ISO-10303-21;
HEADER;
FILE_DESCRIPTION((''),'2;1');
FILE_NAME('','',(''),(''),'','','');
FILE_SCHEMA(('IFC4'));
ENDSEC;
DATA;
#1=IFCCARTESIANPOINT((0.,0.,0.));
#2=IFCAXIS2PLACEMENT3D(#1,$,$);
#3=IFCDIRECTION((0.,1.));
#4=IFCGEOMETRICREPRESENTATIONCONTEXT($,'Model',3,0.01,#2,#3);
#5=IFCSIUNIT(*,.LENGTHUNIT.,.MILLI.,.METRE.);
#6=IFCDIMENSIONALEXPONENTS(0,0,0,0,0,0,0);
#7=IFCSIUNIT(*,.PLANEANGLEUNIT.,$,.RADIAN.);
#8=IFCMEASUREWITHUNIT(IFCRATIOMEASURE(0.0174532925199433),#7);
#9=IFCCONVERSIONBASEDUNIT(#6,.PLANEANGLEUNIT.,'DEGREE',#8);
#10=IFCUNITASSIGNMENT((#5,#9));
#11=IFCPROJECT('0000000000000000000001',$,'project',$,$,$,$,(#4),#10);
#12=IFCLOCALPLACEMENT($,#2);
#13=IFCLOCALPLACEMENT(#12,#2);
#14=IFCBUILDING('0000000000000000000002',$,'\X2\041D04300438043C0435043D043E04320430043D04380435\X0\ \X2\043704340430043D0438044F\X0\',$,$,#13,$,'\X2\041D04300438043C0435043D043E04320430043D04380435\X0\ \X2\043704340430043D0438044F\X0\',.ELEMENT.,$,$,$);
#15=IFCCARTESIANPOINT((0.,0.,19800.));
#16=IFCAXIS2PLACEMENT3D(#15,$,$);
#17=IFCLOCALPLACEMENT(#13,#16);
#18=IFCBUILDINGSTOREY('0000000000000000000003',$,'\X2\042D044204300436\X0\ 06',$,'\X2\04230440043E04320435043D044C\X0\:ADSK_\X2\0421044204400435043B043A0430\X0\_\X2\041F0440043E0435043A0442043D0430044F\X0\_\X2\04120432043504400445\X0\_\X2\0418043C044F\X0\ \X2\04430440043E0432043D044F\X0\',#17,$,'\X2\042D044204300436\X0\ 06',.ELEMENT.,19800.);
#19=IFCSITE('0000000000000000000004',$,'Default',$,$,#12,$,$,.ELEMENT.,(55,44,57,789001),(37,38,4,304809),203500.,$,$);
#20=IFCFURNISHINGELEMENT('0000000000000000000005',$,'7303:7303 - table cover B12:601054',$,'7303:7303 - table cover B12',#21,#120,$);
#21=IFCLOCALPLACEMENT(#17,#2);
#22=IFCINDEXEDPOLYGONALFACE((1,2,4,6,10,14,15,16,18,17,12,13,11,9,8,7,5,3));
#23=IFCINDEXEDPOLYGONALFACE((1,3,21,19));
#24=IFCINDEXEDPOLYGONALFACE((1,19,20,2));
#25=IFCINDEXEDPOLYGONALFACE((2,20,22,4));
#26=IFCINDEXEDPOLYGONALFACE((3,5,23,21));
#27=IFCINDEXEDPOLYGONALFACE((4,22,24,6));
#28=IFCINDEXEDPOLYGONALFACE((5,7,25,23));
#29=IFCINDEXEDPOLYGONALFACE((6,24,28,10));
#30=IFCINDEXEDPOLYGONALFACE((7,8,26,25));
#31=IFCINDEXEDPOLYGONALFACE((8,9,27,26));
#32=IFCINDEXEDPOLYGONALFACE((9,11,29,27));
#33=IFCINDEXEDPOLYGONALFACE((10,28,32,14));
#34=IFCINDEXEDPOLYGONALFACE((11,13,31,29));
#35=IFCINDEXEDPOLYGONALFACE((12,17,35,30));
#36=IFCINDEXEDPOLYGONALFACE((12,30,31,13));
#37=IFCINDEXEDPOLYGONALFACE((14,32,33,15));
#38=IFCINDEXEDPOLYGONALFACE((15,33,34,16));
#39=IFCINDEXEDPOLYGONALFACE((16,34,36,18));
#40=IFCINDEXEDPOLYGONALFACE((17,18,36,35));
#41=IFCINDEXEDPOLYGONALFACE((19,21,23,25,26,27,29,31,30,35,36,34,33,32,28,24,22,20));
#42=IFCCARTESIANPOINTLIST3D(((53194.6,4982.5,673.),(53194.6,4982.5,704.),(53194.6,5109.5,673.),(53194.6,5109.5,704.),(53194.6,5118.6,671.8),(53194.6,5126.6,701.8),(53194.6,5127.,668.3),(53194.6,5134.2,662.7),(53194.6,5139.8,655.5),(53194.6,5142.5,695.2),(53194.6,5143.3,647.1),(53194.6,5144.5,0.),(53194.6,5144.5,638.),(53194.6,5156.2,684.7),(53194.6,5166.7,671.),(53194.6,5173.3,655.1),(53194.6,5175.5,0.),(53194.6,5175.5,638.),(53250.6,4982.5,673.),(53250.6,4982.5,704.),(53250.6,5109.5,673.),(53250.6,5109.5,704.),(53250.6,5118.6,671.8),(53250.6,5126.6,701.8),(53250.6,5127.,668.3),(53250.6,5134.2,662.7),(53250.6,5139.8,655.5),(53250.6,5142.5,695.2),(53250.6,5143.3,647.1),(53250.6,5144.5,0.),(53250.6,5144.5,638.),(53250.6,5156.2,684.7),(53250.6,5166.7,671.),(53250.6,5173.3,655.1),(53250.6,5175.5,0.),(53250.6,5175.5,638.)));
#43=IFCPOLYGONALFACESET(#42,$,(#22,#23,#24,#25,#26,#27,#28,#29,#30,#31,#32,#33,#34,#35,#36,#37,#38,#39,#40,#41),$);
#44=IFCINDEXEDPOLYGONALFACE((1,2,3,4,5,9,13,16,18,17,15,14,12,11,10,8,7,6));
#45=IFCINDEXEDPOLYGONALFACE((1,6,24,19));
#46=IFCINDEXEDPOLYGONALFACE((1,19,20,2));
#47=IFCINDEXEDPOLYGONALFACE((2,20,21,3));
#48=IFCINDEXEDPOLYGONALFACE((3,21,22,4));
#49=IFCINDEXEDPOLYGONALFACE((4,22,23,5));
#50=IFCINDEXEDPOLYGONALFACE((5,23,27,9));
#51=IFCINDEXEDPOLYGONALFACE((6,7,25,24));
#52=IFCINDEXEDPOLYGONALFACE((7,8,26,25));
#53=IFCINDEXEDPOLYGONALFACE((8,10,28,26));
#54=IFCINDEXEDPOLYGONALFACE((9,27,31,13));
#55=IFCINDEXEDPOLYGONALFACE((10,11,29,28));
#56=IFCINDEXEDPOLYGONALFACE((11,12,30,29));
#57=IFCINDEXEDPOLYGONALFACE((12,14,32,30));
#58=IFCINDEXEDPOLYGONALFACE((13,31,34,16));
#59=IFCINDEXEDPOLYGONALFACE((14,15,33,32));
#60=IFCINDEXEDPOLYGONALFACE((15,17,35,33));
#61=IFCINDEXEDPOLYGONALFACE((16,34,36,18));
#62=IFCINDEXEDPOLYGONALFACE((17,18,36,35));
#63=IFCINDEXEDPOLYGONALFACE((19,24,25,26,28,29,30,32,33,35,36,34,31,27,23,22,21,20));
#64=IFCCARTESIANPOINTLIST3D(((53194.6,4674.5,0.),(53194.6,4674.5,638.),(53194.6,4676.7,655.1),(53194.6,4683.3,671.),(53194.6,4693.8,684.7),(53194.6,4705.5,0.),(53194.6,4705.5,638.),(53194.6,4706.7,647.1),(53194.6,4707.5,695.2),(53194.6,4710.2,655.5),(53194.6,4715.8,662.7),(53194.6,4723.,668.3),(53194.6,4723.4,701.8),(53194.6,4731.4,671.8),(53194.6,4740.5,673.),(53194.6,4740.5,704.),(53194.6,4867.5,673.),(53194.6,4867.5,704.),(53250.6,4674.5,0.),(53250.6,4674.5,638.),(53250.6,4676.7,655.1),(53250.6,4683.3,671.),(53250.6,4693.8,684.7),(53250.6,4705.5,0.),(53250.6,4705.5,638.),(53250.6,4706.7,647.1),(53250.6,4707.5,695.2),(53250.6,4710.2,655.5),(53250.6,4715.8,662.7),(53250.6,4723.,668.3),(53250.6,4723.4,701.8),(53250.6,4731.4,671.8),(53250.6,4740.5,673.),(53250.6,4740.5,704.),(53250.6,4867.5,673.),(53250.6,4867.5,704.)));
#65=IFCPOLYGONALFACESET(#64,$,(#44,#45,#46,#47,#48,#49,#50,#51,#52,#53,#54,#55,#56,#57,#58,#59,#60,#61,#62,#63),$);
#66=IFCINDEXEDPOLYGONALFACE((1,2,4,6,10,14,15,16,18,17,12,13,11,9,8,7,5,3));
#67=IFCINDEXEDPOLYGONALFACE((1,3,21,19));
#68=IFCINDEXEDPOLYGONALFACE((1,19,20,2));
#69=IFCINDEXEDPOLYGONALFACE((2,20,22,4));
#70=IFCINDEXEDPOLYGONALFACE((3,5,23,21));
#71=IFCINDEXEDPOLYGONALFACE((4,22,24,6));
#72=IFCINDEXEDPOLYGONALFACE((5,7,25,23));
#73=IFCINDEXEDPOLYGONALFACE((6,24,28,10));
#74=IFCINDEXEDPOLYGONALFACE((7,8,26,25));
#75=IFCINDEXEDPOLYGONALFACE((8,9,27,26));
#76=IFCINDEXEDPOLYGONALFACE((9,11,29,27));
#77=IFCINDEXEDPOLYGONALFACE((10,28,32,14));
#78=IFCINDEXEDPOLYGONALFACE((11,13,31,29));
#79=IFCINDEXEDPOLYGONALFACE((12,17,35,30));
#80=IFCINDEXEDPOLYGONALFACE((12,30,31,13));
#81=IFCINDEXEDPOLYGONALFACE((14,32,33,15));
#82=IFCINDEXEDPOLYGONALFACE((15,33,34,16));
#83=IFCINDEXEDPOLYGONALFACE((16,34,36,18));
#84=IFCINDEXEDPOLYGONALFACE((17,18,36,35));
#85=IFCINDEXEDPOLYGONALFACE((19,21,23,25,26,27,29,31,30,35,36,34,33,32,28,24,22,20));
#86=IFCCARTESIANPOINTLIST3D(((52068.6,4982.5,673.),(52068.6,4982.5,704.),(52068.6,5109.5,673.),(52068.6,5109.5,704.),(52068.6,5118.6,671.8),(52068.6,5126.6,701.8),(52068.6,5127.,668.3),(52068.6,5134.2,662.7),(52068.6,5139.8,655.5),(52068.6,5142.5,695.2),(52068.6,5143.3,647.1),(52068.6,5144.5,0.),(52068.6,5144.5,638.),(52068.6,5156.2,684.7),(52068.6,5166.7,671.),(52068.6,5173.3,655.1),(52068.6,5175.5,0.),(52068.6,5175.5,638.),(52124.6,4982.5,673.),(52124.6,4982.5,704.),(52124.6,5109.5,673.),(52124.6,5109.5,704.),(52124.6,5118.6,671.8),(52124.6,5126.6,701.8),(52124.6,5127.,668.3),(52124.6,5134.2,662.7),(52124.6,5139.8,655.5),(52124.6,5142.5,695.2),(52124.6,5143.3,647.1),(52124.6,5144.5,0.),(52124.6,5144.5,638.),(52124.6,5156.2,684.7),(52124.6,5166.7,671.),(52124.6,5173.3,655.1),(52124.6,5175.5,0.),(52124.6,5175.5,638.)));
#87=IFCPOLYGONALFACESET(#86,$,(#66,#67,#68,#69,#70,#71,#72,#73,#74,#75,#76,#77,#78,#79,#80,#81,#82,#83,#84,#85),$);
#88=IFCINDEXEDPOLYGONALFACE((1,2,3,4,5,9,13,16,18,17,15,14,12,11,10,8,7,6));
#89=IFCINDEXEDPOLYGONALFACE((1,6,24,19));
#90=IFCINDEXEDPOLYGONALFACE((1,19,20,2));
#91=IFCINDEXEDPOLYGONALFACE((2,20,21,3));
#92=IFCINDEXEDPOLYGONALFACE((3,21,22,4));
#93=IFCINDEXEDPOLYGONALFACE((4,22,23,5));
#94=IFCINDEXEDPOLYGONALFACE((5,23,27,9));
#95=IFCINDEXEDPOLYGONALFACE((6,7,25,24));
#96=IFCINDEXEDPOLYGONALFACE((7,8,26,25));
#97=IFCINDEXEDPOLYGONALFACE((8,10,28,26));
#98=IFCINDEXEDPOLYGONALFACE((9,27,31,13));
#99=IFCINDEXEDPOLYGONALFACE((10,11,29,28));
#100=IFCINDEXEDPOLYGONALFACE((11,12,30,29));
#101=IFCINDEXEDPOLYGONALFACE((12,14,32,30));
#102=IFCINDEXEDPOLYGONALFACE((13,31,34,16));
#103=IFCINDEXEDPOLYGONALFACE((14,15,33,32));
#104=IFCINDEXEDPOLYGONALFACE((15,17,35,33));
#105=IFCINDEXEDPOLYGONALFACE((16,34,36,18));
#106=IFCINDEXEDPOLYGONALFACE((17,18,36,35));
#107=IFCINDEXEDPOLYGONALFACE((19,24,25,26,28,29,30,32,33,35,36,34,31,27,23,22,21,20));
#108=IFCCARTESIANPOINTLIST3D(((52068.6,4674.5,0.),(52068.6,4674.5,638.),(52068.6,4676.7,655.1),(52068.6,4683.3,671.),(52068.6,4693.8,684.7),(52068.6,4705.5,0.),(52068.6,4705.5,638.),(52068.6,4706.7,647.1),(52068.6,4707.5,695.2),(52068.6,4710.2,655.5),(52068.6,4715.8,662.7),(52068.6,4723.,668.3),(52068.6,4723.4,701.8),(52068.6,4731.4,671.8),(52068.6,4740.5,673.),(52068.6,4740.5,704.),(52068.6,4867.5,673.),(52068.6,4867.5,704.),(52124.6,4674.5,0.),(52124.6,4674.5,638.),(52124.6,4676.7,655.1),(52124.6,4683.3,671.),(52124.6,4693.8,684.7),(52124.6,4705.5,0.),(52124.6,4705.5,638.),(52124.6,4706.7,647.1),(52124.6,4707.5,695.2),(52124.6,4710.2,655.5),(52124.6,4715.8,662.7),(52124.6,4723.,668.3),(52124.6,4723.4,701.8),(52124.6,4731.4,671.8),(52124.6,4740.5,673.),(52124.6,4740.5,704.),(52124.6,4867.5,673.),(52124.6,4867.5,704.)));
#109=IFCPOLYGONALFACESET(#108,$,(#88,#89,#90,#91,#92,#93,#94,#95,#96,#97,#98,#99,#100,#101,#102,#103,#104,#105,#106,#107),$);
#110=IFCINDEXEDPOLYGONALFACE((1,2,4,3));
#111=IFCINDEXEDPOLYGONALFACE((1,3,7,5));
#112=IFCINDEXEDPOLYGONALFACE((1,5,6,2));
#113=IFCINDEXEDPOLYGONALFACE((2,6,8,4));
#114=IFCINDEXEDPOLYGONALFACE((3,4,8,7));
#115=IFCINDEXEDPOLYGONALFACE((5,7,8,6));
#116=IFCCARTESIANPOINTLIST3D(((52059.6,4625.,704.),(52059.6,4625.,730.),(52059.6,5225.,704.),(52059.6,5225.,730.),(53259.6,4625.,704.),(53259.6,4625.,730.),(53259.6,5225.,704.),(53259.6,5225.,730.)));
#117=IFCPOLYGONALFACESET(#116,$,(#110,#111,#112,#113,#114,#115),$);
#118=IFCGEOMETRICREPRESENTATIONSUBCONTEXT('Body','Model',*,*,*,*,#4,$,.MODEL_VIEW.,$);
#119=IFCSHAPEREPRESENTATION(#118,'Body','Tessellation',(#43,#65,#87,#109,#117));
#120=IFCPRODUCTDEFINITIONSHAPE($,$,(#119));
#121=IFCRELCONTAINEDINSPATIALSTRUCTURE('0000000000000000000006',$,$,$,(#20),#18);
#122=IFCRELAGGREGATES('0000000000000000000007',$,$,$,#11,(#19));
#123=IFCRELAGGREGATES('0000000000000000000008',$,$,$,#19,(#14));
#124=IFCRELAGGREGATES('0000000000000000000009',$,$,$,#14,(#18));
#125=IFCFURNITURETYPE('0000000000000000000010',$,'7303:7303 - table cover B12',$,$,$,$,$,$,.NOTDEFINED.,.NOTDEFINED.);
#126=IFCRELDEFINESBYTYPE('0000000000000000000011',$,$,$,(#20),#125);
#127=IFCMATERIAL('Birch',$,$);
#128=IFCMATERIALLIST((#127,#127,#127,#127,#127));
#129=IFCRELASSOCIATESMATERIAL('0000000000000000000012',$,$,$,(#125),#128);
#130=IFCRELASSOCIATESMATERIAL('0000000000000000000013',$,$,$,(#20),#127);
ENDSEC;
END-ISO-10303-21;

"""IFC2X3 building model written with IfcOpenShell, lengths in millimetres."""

from ifc_helpers import new_model, entity, si_unit, converted_unit, direction, frame, frame_2d, origin, origin_2d_with_axis, place, context, subcontext, project, spatial, polyline, circle_curve, parameter, trimmed, segment, composite_curve, rectangle, outline, extrude, source, transform, mapped, material, material_list, type_object, type_shapes, element, save


model = new_model("IFC2X3")

# Units and contexts
model_context = context("Model", 3, precision=0.01, world=origin(), true_north=direction((0.0, 1.0)))
body_context = subcontext(model_context, "Body", "Model", "MODEL_VIEW")
ifc_project = project(units=[si_unit("LENGTHUNIT", "METRE", prefix="MILLI"), converted_unit("PLANEANGLEUNIT", "DEGREE", entity("IfcRatioMeasure", 0.0174532925199433), si_unit("PLANEANGLEUNIT", "RADIAN"), dimensions=[0, 0, 0, 0, 0, 0, 0])], contexts=[model_context])

# Site, building, storey
site_placement = place(None, origin())
site = spatial("IfcSite", under=ifc_project, at=site_placement, Name="Default", CompositionType="ELEMENT", RefLatitude=(55, 44, 57, 789001), RefLongitude=(37, 38, 4, 304809), RefElevation=203500.0)
building_placement = place(site_placement, origin())
building = spatial("IfcBuilding", under=site, at=building_placement, Name="Наименование здания", LongName="Наименование здания", CompositionType="ELEMENT")
storey_placement = place(building_placement, frame((0.0, 0.0, 19800.0)))
storey = spatial("IfcBuildingStorey", under=building, at=storey_placement, Name="Этаж 06", ObjectType="Уровень:ADSK_Стрелка_Проектная_Вверх_Имя уровня", LongName="Этаж 06", CompositionType="ELEMENT", Elevation=19800.0)

# Furnishing element
ifc_material_1 = material(Name="Birch")
ifc_material_list_1 = material_list([ifc_material_1, ifc_material_1, ifc_material_1, ifc_material_1, ifc_material_1])
furniture_type = type_object("IfcFurnitureType", Name="7303:7303 - table cover B12", material=ifc_material_list_1)
shared_shape_1 = source(origin(), body_context, "Body", "SweptSolid", [
    extrude(outline(composite_curve([segment(polyline([(-200.2, -120.5), (-169.2, -120.5)]), True, "CONTINUOUS"), segment(polyline([(-169.2, -120.5), (-169.2, 6.5)]), True, "CONTINUOUS"), segment(trimmed(circle_curve(frame_2d((-134.2, 6.5), x_axis=(0.0, -1.0)), 35.0), [parameter(180.0)], [parameter(270.0)], True, "PARAMETER"), False, "CONTINUOUS"), segment(polyline([(-134.2, 41.5), (503.8, 41.5)]), True, "CONTINUOUS"), segment(polyline([(503.8, 41.5), (503.8, 72.5)]), True, "CONTINUOUS"), segment(polyline([(503.8, 72.5), (-134.2, 72.5)]), True, "CONTINUOUS"), segment(trimmed(circle_curve(frame_2d((-134.2, 6.5), x_axis=(0.0, -1.0)), 66.0), [parameter(180.0)], [parameter(270.0)], True, "PARAMETER"), True, "CONTINUOUS"), segment(polyline([(-200.2, 6.5), (-200.2, -120.5)]), True, "CONTINUOUS")], self_intersect=False)), frame((535.0, 178.0, 503.8), z_axis=(1.0, 0.0, 0.0), x_axis=(0.0, 0.0, -1.0)), (0.0, 0.0, 1.0), 56.0),
    extrude(outline(composite_curve([segment(polyline([(-120.5, -200.2), (6.5, -200.2)]), True, "CONTINUOUS"), segment(trimmed(circle_curve(frame_2d((6.5, -134.2), x_axis=(-1.0, 0.0)), 66.0), [parameter(90.0)], [parameter(180.0)], True, "PARAMETER"), True, "CONTINUOUS"), segment(polyline([(72.5, -134.2), (72.5, 503.8)]), True, "CONTINUOUS"), segment(polyline([(72.5, 503.8), (41.5, 503.8)]), True, "CONTINUOUS"), segment(polyline([(41.5, 503.8), (41.5, -134.2)]), True, "CONTINUOUS"), segment(trimmed(circle_curve(frame_2d((6.5, -134.2), x_axis=(-1.0, 0.0)), 35.0), [parameter(90.0)], [parameter(180.0)], True, "PARAMETER"), False, "CONTINUOUS"), segment(polyline([(6.5, -169.2), (-120.5, -169.2)]), True, "CONTINUOUS"), segment(polyline([(-120.5, -169.2), (-120.5, -200.2)]), True, "CONTINUOUS")], self_intersect=False)), frame((535.0, -178.0, 503.8), z_axis=(1.0, 0.0, 0.0), x_axis=(0.0, -1.0, 0.0)), (0.0, 0.0, 1.0), 56.0),
    extrude(outline(composite_curve([segment(polyline([(-200.2, -120.5), (-169.2, -120.5)]), True, "CONTINUOUS"), segment(polyline([(-169.2, -120.5), (-169.2, 6.5)]), True, "CONTINUOUS"), segment(trimmed(circle_curve(frame_2d((-134.2, 6.5), x_axis=(0.0, -1.0)), 35.0), [parameter(180.0)], [parameter(270.0)], True, "PARAMETER"), False, "CONTINUOUS"), segment(polyline([(-134.2, 41.5), (503.8, 41.5)]), True, "CONTINUOUS"), segment(polyline([(503.8, 41.5), (503.8, 72.5)]), True, "CONTINUOUS"), segment(polyline([(503.8, 72.5), (-134.2, 72.5)]), True, "CONTINUOUS"), segment(trimmed(circle_curve(frame_2d((-134.2, 6.5), x_axis=(0.0, -1.0)), 66.0), [parameter(180.0)], [parameter(270.0)], True, "PARAMETER"), True, "CONTINUOUS"), segment(polyline([(-200.2, 6.5), (-200.2, -120.5)]), True, "CONTINUOUS")], self_intersect=False)), frame((-591.0, 178.0, 503.8), z_axis=(1.0, 0.0, 0.0), x_axis=(0.0, 0.0, -1.0)), (0.0, 0.0, 1.0), 56.0),
    extrude(outline(composite_curve([segment(polyline([(-120.5, -200.2), (6.5, -200.2)]), True, "CONTINUOUS"), segment(trimmed(circle_curve(frame_2d((6.5, -134.2), x_axis=(-1.0, 0.0)), 66.0), [parameter(90.0)], [parameter(180.0)], True, "PARAMETER"), True, "CONTINUOUS"), segment(polyline([(72.5, -134.2), (72.5, 503.8)]), True, "CONTINUOUS"), segment(polyline([(72.5, 503.8), (41.5, 503.8)]), True, "CONTINUOUS"), segment(polyline([(41.5, 503.8), (41.5, -134.2)]), True, "CONTINUOUS"), segment(trimmed(circle_curve(frame_2d((6.5, -134.2), x_axis=(-1.0, 0.0)), 35.0), [parameter(90.0)], [parameter(180.0)], True, "PARAMETER"), False, "CONTINUOUS"), segment(polyline([(6.5, -169.2), (-120.5, -169.2)]), True, "CONTINUOUS"), segment(polyline([(-120.5, -169.2), (-120.5, -200.2)]), True, "CONTINUOUS")], self_intersect=False)), frame((-591.0, -178.0, 503.8), z_axis=(1.0, 0.0, 0.0), x_axis=(0.0, -1.0, 0.0)), (0.0, 0.0, 1.0), 56.0),
    extrude(rectangle(XDim=1200.0, YDim=600.0, at=origin_2d_with_axis()), frame((0.0, 0.0, 704.0), z_axis=(0.0, 0.0, 1.0), x_axis=(-1.0, 0.0, 0.0)), (0.0, 0.0, 1.0), 26.0),
])
type_shapes(furniture_type, [shared_shape_1])
for number, where, name in (
    (1, (52659.6, 4925.0, 0.0), "7303:7303 - table cover B12:601054"),
):
    element("IfcFurnishingElement", number, at=place(storey_placement, frame(where)), inside=storey, type_object=furniture_type, material=ifc_material_1, Name=name, ObjectType="7303:7303 - table cover B12", context=body_context, shape_type="MappedRepresentation", body=[
        mapped(shared_shape_1, transform((0.0, 0.0, 0.0), scale=1.0)),
    ])

save(model, "model.ifc")
